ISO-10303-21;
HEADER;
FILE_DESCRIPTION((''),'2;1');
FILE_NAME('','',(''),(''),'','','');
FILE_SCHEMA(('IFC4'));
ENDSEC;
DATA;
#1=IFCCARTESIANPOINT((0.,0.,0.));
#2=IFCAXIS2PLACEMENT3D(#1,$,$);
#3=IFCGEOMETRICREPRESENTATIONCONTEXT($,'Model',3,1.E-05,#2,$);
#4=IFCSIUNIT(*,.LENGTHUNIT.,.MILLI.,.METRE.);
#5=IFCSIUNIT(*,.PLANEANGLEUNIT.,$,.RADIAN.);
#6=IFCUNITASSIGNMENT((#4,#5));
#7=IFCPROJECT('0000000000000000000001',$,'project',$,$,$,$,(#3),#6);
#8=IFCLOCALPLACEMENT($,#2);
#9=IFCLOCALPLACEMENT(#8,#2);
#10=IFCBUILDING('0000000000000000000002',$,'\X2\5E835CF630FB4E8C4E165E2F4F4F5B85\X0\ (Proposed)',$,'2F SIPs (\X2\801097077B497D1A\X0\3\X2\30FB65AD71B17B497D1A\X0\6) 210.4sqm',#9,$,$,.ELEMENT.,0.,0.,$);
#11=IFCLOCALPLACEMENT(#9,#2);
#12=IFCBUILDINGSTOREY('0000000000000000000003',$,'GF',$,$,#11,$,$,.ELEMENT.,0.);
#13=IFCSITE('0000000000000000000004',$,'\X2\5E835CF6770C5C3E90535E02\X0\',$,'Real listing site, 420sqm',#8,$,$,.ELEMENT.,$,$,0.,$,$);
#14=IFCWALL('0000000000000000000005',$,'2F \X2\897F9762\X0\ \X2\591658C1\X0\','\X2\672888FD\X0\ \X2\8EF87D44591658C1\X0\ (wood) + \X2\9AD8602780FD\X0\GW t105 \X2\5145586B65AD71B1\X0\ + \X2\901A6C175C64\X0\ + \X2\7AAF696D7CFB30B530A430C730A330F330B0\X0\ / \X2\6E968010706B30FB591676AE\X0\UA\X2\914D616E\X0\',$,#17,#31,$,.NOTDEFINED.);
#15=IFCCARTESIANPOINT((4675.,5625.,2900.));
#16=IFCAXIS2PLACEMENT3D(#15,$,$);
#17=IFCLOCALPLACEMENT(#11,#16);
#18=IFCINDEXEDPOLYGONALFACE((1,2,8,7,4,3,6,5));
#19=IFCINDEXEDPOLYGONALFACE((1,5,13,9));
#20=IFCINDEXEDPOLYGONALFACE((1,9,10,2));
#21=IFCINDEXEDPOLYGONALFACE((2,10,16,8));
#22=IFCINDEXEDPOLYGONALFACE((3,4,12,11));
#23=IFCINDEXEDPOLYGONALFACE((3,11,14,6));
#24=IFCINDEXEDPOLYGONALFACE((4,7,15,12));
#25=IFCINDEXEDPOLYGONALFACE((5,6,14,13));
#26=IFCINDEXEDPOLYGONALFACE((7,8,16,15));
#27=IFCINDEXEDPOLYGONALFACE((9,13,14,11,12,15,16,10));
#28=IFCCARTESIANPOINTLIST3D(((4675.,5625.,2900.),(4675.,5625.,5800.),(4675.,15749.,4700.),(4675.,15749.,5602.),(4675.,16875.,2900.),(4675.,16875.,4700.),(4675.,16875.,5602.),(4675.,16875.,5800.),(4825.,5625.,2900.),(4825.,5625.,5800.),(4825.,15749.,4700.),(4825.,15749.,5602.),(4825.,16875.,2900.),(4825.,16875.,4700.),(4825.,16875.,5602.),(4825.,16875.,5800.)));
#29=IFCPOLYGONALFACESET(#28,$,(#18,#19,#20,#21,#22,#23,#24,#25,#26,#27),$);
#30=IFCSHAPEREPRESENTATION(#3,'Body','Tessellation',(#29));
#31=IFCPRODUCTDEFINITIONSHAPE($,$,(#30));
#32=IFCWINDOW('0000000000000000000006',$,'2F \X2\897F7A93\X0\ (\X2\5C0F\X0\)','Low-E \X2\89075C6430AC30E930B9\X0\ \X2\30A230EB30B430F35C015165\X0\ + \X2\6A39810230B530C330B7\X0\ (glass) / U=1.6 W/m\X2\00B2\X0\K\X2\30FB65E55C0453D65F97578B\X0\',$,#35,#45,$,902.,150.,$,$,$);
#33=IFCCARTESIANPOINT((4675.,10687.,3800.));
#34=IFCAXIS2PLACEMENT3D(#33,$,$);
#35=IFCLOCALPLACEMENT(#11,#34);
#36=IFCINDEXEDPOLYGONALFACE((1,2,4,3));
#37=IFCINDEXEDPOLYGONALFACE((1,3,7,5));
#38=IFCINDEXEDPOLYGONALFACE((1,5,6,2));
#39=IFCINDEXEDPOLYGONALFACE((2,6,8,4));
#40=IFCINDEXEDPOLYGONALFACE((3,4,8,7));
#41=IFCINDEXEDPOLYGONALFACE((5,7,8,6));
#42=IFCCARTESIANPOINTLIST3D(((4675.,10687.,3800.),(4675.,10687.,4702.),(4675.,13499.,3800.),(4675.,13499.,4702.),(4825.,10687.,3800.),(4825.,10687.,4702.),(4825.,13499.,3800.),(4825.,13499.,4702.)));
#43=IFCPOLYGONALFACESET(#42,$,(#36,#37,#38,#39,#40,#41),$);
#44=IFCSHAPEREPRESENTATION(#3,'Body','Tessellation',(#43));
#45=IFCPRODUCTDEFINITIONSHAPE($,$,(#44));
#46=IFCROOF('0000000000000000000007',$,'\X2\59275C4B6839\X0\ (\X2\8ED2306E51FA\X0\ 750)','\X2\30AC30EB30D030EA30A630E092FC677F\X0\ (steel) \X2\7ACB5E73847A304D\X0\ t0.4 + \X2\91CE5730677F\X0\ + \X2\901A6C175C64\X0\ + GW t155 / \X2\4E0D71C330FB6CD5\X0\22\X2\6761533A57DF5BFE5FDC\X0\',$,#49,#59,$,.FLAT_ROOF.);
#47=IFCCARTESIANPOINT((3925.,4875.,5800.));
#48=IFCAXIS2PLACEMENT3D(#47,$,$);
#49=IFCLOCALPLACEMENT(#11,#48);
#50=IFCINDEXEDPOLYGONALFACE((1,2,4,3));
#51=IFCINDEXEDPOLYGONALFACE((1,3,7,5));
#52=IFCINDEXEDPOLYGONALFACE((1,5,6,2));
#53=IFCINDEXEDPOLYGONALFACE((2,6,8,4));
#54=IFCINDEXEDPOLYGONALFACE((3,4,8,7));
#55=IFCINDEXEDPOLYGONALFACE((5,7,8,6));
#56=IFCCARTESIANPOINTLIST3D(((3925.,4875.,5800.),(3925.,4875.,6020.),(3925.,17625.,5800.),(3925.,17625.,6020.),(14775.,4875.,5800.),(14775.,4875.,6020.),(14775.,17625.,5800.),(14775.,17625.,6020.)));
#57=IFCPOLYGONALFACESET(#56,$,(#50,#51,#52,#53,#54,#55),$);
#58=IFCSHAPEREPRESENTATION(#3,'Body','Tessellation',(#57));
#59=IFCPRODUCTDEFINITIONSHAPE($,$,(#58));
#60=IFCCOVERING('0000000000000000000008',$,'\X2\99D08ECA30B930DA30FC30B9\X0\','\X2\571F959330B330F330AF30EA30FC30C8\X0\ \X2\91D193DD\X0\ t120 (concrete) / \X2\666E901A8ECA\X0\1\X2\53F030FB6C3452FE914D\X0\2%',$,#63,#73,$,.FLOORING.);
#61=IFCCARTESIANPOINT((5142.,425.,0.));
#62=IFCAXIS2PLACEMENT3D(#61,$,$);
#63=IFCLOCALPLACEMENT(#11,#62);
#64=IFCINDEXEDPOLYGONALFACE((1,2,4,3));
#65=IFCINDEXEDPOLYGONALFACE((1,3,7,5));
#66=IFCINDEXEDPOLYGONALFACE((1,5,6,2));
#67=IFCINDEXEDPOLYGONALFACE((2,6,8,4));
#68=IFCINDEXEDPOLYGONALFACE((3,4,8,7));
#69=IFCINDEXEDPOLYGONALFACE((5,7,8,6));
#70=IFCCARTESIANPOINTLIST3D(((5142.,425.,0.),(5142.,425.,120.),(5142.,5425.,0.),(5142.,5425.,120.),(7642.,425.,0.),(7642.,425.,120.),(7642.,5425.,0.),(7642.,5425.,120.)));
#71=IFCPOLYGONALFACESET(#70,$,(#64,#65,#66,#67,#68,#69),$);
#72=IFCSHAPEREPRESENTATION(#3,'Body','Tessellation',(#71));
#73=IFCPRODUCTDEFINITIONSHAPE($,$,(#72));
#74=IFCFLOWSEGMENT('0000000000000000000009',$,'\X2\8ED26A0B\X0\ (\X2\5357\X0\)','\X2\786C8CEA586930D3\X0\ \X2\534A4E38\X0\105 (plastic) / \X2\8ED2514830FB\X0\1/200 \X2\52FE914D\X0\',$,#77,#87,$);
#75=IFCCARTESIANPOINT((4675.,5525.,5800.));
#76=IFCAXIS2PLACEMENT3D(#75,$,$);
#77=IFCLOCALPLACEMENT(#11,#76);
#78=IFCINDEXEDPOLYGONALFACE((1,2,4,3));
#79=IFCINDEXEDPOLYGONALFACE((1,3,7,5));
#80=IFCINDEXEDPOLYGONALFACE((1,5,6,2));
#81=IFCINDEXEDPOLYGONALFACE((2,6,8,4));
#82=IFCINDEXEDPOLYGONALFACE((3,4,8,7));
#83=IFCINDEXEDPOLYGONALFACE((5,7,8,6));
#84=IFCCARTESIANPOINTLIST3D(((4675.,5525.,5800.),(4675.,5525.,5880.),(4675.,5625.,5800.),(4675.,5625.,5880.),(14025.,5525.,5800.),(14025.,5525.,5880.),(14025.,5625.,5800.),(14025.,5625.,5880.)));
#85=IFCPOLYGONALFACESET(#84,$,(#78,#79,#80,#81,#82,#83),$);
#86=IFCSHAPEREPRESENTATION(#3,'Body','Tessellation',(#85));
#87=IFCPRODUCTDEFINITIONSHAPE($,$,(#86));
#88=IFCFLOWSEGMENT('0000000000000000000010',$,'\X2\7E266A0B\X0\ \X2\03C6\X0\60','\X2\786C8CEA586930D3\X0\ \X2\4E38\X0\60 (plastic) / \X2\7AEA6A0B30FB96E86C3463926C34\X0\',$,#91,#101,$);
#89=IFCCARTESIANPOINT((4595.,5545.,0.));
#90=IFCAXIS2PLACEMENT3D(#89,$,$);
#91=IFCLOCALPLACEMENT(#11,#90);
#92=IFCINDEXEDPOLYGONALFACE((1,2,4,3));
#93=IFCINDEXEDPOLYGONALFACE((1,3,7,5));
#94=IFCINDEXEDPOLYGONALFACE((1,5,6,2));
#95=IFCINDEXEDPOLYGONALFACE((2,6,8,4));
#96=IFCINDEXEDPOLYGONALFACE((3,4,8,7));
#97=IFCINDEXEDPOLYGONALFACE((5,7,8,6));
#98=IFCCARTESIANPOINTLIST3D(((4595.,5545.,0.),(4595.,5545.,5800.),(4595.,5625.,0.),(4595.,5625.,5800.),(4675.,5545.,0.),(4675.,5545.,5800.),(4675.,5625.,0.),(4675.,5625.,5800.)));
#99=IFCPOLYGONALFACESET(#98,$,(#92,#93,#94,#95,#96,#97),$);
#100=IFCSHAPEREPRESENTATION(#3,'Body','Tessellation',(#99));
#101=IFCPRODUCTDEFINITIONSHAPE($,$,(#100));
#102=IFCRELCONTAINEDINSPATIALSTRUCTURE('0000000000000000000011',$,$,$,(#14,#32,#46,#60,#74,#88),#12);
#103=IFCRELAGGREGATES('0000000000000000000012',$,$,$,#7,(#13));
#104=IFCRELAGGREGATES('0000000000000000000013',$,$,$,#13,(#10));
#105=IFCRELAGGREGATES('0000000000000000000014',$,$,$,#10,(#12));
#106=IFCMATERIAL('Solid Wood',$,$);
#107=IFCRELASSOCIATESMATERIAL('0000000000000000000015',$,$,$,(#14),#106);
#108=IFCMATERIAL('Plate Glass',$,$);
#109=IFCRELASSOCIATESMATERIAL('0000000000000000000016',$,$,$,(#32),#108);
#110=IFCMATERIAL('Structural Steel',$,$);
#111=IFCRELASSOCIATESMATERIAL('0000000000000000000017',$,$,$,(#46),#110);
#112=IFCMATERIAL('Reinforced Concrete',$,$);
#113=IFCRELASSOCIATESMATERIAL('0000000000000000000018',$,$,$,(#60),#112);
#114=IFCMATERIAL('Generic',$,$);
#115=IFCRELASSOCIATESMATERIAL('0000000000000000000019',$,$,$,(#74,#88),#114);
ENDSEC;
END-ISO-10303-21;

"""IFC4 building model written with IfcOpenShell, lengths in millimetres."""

from ifc_helpers import new_model, si_unit, frame, frame_2d, origin, place, context, project, spatial, rectangle, extrude, material, element, fill, save


model = new_model("IFC4")

# Units and contexts
model_context = context("Model", 3, precision=1e-05, world=origin())
ifc_project = project(units=[si_unit("LENGTHUNIT", "METRE", prefix="MILLI"), si_unit("PLANEANGLEUNIT", "RADIAN")], contexts=[model_context])

# Site, building, storey
site_placement = place(None, origin())
site = spatial("IfcSite", under=ifc_project, at=site_placement, Name="広島県尾道市", ObjectType="Real listing site, 420sqm", CompositionType="ELEMENT", RefElevation=0.0)
building_placement = place(site_placement, origin())
building = spatial("IfcBuilding", under=site, at=building_placement, Name="広島・二世帯住宅 (Proposed)", ObjectType="2F SIPs (耐震等級3・断熱等級6) 210.4sqm", CompositionType="ELEMENT", ElevationOfRefHeight=0.0, ElevationOfTerrain=0.0)
storey_placement = place(building_placement, origin())
storey = spatial("IfcBuildingStorey", under=building, at=storey_placement, Name="GF", CompositionType="ELEMENT", Elevation=0.0)

# Shared definitions
ifc_material_1 = material(Name="Solid Wood")

# Shared definitions
ifc_material_2 = material(Name="Reinforced Concrete")

# Shared definitions
ifc_material_3 = material(Name="Plate Glass")

# Wall, opening, window
wall_1_placement = place(storey_placement, frame((4675.0, 5625.0, 2900.0)))
wall_1 = element("IfcWall", 1, at=wall_1_placement, inside=storey, material=ifc_material_1, Name="2F 西面 外壁", Description="木製 軸組外壁 (wood) + 高性能GW t105 充填断熱 + 通気層 + 窯業系サイディング / 準耐火・外皮UA配慮", PredefinedType="NOTDEFINED", context=model_context, shape_type="SweptSolid", body=[
    extrude(rectangle(XDim=150.0, YDim=11250.0, at=frame_2d((75.0, 5625.0))), frame((4675.0, 5625.0, 2900.0)), (0.0, 0.0, 1.0), 2900.0),
])
opening_1_placement = place(storey_placement, frame((4675.0, 10687.0, 3800.0)))
opening_1 = element("IfcOpeningElement", 2, at=opening_1_placement, cuts=wall_1, PredefinedType="NOTDEFINED", context=model_context, shape_type="SweptSolid", body=[
    extrude(rectangle(XDim=150.0, YDim=2812.0, at=frame_2d((75.0, 1406.0))), frame((4675.0, 10687.0, 3800.0)), (0.0, 0.0, 1.0), 902.0),
])
window_1_placement = place(storey_placement, frame((4675.0, 10687.0, 3800.0)))
window_1 = element("IfcWindow", 3, at=window_1_placement, inside=storey, material=ifc_material_3, Name="2F 西窓 (小)", Description="Low-E 複層ガラス アルゴン封入 + 樹脂サッシ (glass) / U=1.6 W/m²K・日射取得型", OverallHeight=902.0, OverallWidth=150.0, context=model_context, shape_type="SweptSolid", body=[
    extrude(rectangle(XDim=150.0, YDim=2812.0, at=frame_2d((75.0, 1406.0))), frame((4675.0, 10687.0, 3800.0)), (0.0, 0.0, 1.0), 902.0),
])
fill(opening_1, window_1)

# Roof
ifc_material_4 = material(Name="Structural Steel")
roof_placement = place(storey_placement, frame((3925.0, 4875.0, 5800.0)))
element("IfcRoof", 4, at=roof_placement, inside=storey, material=ifc_material_4, Name="大屋根 (軒の出 750)", Description="ガルバリウム鋼板 (steel) 立平葺き t0.4 + 野地板 + 通気層 + GW t155 / 不燃・法22条区域対応", PredefinedType="FLAT_ROOF", context=model_context, shape_type="SweptSolid", body=[
    extrude(rectangle(XDim=10850.0, YDim=12750.0, at=frame_2d((5425.0, 6375.0))), frame((3925.0, 4875.0, 5800.0)), (0.0, 0.0, 1.0), 220.0),
])

# Covering
covering_placement = place(storey_placement, frame((5142.0, 425.0, 0.0)))
element("IfcCovering", 5, at=covering_placement, inside=storey, material=ifc_material_2, Name="駐車スペース", Description="土間コンクリート 金鏝 t120 (concrete) / 普通車1台・水勾配2%", PredefinedType="FLOORING", context=model_context, shape_type="SweptSolid", body=[
    extrude(rectangle(XDim=2500.0, YDim=5000.0, at=frame_2d((1250.0, 2500.0))), frame((5142.0, 425.0, 0.0)), (0.0, 0.0, 1.0), 120.0),
])

# Flow segments
ifc_material_5 = material(Name="Generic")
flow_segment_1_placement = place(storey_placement, frame((4675.0, 5525.0, 5800.0)))
element("IfcFlowSegment", 6, at=flow_segment_1_placement, inside=storey, material=ifc_material_5, Name="軒樋 (南)", Description="硬質塩ビ 半丸105 (plastic) / 軒先・1/200 勾配", context=model_context, shape_type="SweptSolid", body=[
    extrude(rectangle(XDim=9350.0, YDim=100.0, at=frame_2d((4675.0, 50.0))), frame((4675.0, 5525.0, 5800.0)), (0.0, 0.0, 1.0), 80.0),
])
flow_segment_2_placement = place(storey_placement, frame((4595.0, 5545.0, 0.0)))
element("IfcFlowSegment", 7, at=flow_segment_2_placement, inside=storey, material=ifc_material_5, Name="縦樋 φ60", Description="硬質塩ビ 丸60 (plastic) / 竪樋・雨水排水", context=model_context, shape_type="SweptSolid", body=[
    extrude(rectangle(XDim=80.0, YDim=80.0, at=frame_2d((40.0, 40.0))), frame((4595.0, 5545.0, 0.0)), (0.0, 0.0, 1.0), 5800.0),
])

save(model, "model.ifc")
